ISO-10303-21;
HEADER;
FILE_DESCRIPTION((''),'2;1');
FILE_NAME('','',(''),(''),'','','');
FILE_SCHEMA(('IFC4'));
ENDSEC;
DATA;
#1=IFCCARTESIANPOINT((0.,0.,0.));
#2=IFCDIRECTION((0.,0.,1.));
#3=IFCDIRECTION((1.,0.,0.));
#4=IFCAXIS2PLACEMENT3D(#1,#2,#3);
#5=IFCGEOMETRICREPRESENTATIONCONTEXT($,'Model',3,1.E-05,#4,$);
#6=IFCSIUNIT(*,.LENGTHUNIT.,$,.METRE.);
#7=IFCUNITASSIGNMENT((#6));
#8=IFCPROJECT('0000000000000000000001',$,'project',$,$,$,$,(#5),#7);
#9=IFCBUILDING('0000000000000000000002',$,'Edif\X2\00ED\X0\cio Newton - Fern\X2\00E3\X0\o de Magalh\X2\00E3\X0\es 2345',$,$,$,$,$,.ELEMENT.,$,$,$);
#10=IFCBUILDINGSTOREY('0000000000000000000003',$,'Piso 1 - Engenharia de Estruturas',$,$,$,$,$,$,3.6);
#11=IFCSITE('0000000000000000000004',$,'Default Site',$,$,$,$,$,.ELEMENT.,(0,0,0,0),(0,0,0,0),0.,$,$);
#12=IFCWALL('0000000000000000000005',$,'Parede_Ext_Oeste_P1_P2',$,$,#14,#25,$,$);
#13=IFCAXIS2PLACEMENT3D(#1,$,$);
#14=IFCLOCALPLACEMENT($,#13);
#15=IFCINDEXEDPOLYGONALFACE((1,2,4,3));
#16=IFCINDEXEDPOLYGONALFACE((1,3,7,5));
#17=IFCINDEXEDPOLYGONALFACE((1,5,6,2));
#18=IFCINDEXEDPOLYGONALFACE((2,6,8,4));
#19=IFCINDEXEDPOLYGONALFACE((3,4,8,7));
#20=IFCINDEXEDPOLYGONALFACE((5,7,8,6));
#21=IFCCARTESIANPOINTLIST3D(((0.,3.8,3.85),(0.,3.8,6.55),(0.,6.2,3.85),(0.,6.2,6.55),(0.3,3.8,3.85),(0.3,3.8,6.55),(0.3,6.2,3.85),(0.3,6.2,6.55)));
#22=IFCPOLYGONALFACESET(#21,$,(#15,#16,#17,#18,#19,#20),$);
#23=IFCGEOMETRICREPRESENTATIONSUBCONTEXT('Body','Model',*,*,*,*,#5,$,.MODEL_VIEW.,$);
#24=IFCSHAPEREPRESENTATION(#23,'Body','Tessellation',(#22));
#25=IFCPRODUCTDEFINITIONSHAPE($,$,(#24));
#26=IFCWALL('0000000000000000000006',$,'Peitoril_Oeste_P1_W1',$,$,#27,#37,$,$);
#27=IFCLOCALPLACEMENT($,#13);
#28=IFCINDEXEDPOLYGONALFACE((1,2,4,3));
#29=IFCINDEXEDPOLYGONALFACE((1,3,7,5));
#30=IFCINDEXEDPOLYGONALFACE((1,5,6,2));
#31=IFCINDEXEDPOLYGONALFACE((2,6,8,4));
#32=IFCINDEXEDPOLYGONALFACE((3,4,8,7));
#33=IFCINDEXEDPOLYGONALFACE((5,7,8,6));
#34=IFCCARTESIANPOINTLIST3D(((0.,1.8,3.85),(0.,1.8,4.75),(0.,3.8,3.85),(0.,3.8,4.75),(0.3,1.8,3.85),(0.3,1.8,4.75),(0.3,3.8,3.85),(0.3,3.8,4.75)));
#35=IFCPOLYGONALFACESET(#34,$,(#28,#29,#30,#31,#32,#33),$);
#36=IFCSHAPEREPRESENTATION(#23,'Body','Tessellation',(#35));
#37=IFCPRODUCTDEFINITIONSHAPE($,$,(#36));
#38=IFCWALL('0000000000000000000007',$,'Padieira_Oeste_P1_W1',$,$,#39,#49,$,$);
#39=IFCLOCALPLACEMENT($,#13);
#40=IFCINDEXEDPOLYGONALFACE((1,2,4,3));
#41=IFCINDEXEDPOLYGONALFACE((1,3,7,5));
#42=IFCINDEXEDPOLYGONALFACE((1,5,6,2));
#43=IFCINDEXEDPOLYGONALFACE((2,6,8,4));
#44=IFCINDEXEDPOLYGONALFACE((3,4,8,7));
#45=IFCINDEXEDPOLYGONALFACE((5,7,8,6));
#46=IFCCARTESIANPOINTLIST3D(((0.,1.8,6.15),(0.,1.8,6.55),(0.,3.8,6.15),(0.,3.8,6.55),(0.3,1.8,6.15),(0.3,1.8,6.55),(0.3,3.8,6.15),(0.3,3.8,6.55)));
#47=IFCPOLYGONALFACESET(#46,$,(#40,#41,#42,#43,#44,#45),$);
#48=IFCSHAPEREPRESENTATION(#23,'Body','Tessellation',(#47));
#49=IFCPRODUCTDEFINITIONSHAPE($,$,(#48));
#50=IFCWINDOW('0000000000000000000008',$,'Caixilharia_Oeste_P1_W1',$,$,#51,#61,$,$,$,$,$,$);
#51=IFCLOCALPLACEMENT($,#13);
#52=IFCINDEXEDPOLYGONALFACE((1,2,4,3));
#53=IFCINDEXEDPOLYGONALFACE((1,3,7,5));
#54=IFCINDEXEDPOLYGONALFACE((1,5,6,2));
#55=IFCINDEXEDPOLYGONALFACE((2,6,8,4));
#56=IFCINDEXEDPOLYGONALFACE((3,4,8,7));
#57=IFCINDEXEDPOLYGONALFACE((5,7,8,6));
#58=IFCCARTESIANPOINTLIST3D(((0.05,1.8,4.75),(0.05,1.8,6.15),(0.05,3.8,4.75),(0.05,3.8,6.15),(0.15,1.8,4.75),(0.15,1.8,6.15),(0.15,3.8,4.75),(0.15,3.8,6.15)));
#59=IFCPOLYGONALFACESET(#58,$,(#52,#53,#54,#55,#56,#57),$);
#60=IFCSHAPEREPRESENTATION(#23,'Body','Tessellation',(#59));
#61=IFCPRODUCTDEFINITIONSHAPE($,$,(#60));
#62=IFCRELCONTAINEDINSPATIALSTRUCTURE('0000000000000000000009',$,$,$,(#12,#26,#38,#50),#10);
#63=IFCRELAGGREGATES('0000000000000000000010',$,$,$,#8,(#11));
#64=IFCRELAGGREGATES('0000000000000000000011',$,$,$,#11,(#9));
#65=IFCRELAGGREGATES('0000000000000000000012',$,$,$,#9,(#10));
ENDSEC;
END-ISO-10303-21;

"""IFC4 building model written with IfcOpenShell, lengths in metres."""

from ifc_helpers import new_model, si_unit, frame, frame_2d, origin_with_axes, place, context, subcontext, project, spatial, rectangle, extrude, element, save


model = new_model("IFC4")

# Units and contexts
model_context = context("Model", 3, precision=1e-05, world=origin_with_axes())
body_context = subcontext(model_context, "Body", "Model", "MODEL_VIEW")
ifc_project = project(units=[si_unit("LENGTHUNIT", "METRE")], contexts=[model_context])

# Site, building, storey
site = spatial("IfcSite", under=ifc_project, Name="Default Site", CompositionType="ELEMENT", RefLatitude=(0, 0, 0, 0), RefLongitude=(0, 0, 0, 0), RefElevation=0.0)
building = spatial("IfcBuilding", under=site, Name="Edifício Newton - Fernão de Magalhães 2345", CompositionType="ELEMENT")
storey = spatial("IfcBuildingStorey", under=building, Name="Piso 1 - Engenharia de Estruturas", Elevation=3.6)

# Walls
wall_1_placement = place(None, frame((0.0, 3.8, 3.85), z_axis=(0.0, 0.0, 1.0), x_axis=(1.0, 0.0, 0.0)))
element("IfcWall", 1, at=wall_1_placement, inside=storey, Name="Parede_Ext_Oeste_P1_P2", context=body_context, shape_type="SweptSolid", body=[
    extrude(rectangle(XDim=0.3, YDim=2.4, at=frame_2d((0.15, 1.2))), origin_with_axes(), (0.0, 0.0, 1.0), 2.7),
])
wall_2_placement = place(None, frame((0.0, 1.8, 3.85), z_axis=(0.0, 0.0, 1.0), x_axis=(1.0, 0.0, 0.0)))
element("IfcWall", 2, at=wall_2_placement, inside=storey, Name="Peitoril_Oeste_P1_W1", context=body_context, shape_type="SweptSolid", body=[
    extrude(rectangle(XDim=0.3, YDim=2.0, at=frame_2d((0.15, 1.0))), origin_with_axes(), (0.0, 0.0, 1.0), 0.9),
])
wall_3_placement = place(None, frame((0.0, 1.8, 6.15), z_axis=(0.0, 0.0, 1.0), x_axis=(1.0, 0.0, 0.0)))
element("IfcWall", 3, at=wall_3_placement, inside=storey, Name="Padieira_Oeste_P1_W1", context=body_context, shape_type="SweptSolid", body=[
    extrude(rectangle(XDim=0.3, YDim=2.0, at=frame_2d((0.15, 1.0))), origin_with_axes(), (0.0, 0.0, 1.0), 0.4),
])

# Window
window_placement = place(None, frame((0.05, 1.8, 4.75), z_axis=(0.0, 0.0, 1.0), x_axis=(1.0, 0.0, 0.0)))
element("IfcWindow", 4, at=window_placement, inside=storey, Name="Caixilharia_Oeste_P1_W1", context=body_context, shape_type="SweptSolid", body=[
    extrude(rectangle(XDim=0.1, YDim=2.0, at=frame_2d((0.05, 1.0))), origin_with_axes(), (0.0, 0.0, 1.0), 1.4),
])

save(model, "model.ifc")
